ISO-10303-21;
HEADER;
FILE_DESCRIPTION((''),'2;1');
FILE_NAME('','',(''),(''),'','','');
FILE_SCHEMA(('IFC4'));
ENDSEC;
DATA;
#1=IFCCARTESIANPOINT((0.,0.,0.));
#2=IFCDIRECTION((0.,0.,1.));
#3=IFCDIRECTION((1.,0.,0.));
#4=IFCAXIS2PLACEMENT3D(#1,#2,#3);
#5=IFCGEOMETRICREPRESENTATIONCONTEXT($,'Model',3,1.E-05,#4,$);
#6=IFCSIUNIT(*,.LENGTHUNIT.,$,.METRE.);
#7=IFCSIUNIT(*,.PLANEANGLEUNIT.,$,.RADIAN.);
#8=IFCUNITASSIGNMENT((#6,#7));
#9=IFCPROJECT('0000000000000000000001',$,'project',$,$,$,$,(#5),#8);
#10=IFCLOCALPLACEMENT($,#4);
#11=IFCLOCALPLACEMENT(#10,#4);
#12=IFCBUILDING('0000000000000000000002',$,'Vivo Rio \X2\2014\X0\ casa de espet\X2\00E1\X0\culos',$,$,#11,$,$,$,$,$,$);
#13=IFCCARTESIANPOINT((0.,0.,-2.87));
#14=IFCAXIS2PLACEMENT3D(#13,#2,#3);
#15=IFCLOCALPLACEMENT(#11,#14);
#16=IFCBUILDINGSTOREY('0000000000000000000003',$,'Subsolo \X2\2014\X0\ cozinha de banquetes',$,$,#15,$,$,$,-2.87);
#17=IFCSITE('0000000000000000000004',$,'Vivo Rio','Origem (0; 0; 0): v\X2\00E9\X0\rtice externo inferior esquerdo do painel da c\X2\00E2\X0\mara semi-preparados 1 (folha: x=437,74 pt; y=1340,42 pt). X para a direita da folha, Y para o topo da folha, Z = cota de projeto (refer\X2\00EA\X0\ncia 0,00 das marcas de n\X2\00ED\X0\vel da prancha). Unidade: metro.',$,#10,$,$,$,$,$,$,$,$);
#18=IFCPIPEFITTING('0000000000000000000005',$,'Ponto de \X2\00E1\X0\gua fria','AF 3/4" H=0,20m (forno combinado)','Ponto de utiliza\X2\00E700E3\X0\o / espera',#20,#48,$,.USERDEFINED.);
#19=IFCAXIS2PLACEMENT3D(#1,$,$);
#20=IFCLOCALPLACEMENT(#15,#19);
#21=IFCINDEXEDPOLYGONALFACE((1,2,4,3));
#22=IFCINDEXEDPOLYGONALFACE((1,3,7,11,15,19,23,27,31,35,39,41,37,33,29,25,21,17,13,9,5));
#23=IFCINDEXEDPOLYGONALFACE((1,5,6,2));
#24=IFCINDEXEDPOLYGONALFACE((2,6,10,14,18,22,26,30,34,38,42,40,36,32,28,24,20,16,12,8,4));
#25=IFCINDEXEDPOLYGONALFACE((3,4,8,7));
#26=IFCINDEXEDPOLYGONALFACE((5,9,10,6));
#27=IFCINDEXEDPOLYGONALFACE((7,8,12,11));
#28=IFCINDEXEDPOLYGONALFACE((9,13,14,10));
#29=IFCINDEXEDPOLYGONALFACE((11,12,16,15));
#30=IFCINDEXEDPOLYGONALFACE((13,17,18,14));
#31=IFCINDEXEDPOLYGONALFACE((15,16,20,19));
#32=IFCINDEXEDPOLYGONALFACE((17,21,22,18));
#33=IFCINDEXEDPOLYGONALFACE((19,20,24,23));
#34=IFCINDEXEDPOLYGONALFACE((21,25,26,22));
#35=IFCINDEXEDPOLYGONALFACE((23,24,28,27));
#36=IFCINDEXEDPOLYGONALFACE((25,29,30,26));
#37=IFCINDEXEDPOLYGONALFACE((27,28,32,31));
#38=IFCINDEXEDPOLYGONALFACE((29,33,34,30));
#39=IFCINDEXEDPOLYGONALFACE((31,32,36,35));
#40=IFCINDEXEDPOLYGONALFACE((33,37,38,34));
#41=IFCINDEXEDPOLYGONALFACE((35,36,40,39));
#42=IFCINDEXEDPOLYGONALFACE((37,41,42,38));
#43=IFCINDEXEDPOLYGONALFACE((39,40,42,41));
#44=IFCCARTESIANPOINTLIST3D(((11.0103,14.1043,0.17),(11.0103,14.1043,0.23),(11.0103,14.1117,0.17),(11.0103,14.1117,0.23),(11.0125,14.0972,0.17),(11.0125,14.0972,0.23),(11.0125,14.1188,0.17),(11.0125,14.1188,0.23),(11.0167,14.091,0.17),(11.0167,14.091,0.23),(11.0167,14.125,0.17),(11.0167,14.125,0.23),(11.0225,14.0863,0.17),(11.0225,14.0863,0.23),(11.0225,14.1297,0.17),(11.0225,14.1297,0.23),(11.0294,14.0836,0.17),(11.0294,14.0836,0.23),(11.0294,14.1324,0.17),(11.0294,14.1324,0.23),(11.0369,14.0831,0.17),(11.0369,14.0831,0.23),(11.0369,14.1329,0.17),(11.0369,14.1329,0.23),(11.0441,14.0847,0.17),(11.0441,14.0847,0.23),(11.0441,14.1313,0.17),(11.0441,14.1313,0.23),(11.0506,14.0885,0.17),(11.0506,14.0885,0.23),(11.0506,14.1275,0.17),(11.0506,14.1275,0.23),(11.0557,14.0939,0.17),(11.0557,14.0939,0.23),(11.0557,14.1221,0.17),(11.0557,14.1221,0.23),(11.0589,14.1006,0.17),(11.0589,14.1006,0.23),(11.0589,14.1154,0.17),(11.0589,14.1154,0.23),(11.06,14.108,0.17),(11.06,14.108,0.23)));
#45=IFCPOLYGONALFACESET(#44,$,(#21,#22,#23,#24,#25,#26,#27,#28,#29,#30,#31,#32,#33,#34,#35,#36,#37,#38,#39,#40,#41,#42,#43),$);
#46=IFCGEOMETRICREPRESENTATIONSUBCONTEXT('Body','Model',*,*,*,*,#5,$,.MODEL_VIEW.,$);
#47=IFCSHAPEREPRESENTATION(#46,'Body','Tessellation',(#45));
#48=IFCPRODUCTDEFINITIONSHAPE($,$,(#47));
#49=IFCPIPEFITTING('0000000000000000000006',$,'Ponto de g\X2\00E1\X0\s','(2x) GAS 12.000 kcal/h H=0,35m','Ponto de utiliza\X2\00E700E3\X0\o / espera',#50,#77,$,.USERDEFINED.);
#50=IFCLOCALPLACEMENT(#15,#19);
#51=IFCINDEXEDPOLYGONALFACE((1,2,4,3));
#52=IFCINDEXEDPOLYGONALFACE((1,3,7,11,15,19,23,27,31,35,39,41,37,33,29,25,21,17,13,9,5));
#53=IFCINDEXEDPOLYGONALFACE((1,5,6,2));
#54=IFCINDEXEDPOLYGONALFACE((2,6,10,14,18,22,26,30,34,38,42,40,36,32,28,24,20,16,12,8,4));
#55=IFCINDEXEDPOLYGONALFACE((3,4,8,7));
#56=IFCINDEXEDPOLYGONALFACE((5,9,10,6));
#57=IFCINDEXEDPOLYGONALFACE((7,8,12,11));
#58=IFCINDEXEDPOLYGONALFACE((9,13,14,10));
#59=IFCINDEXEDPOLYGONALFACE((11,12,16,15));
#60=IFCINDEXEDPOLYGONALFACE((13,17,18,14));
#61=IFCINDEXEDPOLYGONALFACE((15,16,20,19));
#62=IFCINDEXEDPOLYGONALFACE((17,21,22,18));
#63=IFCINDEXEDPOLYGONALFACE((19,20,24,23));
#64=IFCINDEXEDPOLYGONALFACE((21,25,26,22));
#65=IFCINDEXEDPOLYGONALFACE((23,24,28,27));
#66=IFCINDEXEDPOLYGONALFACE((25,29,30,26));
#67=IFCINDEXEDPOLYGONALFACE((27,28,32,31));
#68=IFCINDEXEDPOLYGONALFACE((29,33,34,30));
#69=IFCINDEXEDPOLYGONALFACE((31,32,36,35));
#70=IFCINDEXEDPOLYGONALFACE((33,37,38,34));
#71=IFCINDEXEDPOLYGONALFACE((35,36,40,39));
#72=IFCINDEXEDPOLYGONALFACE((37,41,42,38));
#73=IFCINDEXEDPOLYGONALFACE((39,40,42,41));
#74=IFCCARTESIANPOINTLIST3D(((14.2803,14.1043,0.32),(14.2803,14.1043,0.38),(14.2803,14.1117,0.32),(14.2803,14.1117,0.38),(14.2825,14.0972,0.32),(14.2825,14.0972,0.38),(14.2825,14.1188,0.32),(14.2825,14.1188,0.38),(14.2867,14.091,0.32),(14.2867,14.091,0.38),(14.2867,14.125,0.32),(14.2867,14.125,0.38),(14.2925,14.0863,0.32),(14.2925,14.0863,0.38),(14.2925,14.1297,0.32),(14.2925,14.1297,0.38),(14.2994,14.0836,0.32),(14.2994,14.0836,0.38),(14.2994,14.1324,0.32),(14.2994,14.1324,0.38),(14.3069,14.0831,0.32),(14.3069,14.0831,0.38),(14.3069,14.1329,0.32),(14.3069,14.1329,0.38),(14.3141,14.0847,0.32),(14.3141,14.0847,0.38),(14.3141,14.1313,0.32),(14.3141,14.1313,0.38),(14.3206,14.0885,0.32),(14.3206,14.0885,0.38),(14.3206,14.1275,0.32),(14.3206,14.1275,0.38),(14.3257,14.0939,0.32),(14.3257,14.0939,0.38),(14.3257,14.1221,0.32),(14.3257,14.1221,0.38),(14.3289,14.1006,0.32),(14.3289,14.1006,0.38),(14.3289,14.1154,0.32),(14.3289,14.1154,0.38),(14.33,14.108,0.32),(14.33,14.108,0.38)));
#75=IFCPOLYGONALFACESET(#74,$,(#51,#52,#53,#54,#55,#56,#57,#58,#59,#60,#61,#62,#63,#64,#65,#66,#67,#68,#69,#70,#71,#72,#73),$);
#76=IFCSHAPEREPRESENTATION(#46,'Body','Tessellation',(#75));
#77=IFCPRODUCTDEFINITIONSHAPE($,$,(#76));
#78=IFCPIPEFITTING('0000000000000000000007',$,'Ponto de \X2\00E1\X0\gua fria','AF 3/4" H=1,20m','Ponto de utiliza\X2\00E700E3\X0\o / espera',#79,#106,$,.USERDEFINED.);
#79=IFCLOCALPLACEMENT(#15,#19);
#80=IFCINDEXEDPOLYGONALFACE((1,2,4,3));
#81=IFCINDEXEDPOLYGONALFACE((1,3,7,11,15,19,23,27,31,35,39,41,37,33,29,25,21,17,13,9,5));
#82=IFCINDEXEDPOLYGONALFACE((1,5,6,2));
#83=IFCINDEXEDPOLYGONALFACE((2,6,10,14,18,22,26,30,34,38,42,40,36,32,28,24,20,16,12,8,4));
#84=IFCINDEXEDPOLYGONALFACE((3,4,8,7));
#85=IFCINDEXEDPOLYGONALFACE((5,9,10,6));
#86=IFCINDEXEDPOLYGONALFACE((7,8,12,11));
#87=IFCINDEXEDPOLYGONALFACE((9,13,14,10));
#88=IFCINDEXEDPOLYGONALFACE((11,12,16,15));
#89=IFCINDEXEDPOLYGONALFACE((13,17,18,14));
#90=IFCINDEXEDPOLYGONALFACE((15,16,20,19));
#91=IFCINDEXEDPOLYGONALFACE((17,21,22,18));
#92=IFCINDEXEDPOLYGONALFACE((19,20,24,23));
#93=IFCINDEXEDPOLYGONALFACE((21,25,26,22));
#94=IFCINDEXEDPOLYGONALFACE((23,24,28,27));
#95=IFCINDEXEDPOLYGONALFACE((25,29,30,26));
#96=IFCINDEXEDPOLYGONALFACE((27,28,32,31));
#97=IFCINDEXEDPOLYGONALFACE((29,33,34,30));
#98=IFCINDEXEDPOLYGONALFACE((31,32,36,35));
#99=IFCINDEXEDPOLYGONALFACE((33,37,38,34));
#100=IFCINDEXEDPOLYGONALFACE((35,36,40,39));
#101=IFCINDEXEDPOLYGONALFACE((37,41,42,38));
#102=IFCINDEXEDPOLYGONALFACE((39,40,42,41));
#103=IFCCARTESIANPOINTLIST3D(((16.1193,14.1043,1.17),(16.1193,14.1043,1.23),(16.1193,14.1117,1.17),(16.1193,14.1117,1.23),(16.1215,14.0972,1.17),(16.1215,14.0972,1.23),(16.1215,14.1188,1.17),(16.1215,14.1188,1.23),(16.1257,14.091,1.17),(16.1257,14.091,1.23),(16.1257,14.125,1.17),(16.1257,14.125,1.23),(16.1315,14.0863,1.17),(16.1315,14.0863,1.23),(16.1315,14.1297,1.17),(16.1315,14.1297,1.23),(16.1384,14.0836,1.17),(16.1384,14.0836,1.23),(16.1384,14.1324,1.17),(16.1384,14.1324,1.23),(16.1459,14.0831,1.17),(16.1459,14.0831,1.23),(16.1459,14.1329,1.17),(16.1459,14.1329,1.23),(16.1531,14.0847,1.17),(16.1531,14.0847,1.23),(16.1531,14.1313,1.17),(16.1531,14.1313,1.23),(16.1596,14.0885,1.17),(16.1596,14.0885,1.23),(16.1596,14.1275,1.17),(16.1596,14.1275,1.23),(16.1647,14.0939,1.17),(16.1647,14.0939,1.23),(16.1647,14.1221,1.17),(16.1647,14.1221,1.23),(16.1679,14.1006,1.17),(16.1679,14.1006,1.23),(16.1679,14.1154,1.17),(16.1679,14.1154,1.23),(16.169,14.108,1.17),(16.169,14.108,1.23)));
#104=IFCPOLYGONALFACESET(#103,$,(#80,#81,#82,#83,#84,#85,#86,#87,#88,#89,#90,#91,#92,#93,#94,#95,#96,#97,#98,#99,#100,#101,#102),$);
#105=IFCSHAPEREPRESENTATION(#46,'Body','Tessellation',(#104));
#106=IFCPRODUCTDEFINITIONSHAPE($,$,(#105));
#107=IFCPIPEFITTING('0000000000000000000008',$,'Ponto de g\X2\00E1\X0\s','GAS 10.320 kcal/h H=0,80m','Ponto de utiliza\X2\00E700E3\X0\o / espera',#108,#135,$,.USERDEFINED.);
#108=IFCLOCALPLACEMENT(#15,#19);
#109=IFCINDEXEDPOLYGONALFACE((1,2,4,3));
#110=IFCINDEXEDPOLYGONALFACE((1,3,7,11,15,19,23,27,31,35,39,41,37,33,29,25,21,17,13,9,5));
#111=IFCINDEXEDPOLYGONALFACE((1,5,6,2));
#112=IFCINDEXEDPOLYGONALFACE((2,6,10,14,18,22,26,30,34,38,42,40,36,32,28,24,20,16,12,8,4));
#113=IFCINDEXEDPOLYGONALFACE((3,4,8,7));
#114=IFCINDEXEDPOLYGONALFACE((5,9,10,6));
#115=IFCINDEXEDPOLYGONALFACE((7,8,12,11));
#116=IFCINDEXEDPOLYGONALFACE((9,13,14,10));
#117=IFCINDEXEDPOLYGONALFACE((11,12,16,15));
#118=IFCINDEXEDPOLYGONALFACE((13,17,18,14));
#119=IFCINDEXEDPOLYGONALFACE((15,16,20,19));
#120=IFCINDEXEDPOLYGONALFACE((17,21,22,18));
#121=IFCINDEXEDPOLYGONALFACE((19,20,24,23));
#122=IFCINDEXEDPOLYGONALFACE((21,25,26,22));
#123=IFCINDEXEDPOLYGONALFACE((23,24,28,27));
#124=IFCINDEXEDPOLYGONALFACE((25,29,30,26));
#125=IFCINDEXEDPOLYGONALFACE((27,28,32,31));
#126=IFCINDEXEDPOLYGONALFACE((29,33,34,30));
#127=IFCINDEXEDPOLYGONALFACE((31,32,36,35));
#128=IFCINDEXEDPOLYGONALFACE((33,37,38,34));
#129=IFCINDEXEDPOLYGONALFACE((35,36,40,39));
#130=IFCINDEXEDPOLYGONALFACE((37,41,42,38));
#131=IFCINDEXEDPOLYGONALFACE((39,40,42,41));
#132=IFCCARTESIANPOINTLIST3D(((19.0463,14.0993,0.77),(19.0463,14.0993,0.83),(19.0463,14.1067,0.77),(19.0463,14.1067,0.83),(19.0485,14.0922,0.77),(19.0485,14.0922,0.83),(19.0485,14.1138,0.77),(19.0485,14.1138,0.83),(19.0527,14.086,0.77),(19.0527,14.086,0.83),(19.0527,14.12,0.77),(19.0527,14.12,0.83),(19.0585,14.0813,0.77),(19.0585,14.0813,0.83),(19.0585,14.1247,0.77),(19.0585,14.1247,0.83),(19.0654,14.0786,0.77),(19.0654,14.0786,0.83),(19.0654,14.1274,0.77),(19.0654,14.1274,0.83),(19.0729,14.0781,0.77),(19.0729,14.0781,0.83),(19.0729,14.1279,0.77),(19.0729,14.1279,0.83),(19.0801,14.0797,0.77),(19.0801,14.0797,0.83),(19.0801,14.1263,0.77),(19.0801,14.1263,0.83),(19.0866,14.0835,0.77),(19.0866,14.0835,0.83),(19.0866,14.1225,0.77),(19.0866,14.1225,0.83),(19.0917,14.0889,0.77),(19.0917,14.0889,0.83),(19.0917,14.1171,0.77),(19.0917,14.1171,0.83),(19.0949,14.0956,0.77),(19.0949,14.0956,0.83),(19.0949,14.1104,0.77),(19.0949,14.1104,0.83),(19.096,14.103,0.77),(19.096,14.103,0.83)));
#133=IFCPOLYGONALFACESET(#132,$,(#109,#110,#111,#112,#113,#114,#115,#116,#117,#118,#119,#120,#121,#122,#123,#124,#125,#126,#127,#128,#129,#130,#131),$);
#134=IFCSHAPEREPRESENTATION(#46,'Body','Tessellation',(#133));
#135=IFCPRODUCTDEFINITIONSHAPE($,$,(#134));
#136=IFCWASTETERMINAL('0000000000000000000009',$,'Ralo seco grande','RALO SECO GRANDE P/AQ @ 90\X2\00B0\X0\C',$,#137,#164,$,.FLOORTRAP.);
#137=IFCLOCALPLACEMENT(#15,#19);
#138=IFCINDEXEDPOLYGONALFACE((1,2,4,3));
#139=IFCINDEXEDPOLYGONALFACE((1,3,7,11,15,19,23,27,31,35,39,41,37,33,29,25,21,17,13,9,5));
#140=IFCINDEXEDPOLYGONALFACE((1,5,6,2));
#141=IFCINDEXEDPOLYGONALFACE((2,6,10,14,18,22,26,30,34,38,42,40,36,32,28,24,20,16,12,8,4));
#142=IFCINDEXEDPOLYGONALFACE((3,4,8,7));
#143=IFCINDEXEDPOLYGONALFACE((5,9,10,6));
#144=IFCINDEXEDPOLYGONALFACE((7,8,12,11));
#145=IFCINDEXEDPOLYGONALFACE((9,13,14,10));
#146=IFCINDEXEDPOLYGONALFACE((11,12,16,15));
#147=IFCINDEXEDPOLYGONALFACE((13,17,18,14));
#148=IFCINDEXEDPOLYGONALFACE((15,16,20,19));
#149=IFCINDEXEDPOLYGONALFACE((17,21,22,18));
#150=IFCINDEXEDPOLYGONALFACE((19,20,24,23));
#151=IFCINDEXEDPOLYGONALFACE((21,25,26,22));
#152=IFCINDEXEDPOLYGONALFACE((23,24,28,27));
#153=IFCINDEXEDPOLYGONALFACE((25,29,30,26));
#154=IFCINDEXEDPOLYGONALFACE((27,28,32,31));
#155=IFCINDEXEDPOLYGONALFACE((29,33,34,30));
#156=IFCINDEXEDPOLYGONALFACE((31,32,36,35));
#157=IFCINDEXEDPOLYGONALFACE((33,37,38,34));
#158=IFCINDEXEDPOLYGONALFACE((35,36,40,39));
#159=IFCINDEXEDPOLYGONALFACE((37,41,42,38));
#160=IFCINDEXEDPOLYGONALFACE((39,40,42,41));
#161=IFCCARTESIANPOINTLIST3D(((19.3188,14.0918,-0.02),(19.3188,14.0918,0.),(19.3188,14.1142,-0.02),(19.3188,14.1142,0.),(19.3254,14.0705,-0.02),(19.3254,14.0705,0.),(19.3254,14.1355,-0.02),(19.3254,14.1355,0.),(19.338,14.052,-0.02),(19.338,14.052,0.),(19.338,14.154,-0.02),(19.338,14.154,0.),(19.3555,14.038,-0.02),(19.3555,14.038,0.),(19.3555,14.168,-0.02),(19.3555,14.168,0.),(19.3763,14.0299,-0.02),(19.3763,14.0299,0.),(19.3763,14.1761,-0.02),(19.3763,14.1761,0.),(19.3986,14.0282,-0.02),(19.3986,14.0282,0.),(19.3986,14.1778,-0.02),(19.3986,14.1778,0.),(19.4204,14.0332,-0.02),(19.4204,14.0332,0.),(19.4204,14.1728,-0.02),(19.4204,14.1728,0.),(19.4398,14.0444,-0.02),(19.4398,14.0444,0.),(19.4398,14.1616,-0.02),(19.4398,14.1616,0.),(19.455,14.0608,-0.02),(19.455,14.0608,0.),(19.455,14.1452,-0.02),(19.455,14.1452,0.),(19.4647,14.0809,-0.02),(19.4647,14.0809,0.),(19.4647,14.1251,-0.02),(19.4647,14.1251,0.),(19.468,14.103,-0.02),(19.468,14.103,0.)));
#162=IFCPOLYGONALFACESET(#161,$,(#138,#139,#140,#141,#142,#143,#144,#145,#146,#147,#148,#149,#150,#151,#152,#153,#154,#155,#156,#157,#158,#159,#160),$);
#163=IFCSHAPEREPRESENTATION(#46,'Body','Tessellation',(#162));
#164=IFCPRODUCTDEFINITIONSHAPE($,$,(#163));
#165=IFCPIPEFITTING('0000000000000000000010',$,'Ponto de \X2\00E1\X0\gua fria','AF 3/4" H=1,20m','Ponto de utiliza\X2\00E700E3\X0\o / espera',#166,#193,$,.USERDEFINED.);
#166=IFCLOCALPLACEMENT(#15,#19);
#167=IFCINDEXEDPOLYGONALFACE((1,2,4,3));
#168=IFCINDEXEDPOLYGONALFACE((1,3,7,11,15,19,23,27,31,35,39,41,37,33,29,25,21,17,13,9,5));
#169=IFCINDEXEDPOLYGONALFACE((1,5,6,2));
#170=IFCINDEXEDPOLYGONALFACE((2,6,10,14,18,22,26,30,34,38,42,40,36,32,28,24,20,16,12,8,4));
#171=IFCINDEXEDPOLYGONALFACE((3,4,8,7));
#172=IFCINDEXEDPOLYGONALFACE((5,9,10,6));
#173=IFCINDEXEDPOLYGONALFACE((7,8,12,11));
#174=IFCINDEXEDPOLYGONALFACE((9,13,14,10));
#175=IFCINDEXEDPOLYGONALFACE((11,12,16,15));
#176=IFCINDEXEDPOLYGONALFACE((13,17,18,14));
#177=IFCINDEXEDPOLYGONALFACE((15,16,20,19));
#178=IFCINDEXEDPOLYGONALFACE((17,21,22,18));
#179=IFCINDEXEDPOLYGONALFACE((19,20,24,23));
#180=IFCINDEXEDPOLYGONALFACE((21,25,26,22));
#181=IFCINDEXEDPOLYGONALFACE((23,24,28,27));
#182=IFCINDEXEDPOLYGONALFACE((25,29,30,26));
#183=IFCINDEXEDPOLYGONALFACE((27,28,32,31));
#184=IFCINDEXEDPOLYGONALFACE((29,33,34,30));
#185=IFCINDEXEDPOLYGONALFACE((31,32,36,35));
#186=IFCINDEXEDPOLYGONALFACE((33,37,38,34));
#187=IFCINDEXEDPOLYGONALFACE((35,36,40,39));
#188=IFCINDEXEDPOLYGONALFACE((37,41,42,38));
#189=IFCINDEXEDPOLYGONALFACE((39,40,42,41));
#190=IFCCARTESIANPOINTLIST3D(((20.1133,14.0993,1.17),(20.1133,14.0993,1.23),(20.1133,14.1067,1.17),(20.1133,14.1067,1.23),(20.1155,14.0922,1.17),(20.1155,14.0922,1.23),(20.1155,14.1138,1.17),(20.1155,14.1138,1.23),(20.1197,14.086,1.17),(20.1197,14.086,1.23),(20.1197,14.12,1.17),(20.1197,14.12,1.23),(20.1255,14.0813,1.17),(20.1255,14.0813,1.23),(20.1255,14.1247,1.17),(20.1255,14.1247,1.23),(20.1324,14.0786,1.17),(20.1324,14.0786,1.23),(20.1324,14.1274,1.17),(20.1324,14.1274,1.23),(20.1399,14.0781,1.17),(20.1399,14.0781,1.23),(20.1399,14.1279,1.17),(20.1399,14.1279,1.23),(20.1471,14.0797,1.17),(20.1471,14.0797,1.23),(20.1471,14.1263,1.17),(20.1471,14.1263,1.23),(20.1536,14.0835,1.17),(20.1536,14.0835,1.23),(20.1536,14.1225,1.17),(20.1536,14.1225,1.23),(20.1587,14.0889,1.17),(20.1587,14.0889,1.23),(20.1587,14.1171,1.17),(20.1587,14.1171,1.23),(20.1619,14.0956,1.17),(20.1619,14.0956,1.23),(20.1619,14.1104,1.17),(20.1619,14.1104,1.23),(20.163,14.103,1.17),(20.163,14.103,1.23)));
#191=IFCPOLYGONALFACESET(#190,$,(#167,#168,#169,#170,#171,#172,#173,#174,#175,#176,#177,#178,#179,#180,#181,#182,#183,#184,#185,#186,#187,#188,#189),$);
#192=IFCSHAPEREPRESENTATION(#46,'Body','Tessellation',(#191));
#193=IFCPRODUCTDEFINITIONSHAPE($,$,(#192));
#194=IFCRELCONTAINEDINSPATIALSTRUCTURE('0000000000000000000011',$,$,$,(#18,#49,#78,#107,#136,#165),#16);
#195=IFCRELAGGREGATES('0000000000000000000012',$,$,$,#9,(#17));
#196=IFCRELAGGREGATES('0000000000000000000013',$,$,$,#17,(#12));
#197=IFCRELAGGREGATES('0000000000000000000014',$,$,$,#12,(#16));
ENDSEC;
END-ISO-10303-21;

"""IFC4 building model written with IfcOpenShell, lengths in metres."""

from ifc_helpers import new_model, si_unit, frame, origin_with_axes, origin_2d, place, context, subcontext, project, spatial, circle, extrude, element, save


model = new_model("IFC4")

# Units and contexts
model_context = context("Model", 3, precision=1e-05, world=origin_with_axes())
body_context = subcontext(model_context, "Body", "Model", "MODEL_VIEW")
ifc_project = project(units=[si_unit("LENGTHUNIT", "METRE"), si_unit("PLANEANGLEUNIT", "RADIAN")], contexts=[model_context])

# Site, building, storey
site_placement = place(None, origin_with_axes())
site = spatial("IfcSite", under=ifc_project, at=site_placement, Name="Vivo Rio", Description="Origem (0; 0; 0): vértice externo inferior esquerdo do painel da câmara semi-preparados 1 (folha: x=437,74 pt; y=1340,42 pt). X para a direita da folha, Y para o topo da folha, Z = cota de projeto (referência 0,00 das marcas de nível da prancha). Unidade: metro.")
building_placement = place(site_placement, origin_with_axes())
building = spatial("IfcBuilding", under=site, at=building_placement, Name="Vivo Rio — casa de espetáculos")
storey_placement = place(building_placement, frame((0.0, 0.0, -2.87), z_axis=(0.0, 0.0, 1.0), x_axis=(1.0, 0.0, 0.0)))
storey = spatial("IfcBuildingStorey", under=building, at=storey_placement, Name="Subsolo — cozinha de banquetes", Elevation=-2.87)

# Pipe fittings
pipe_fitting_1_placement = place(storey_placement, origin_with_axes())
element("IfcPipeFitting", 1, at=pipe_fitting_1_placement, inside=storey, Name="Ponto de água fria", Description="AF 3/4\" H=0,20m (forno combinado)", ObjectType="Ponto de utilização / espera", PredefinedType="USERDEFINED", context=body_context, shape_type="SweptSolid", body=[
    extrude(circle(Radius=0.025, at=origin_2d()), frame((11.035, 14.108, 0.17), z_axis=(0.0, 0.0, 1.0), x_axis=(1.0, 0.0, 0.0)), (0.0, 0.0, 1.0), 0.06),
])
pipe_fitting_2_placement = place(storey_placement, origin_with_axes())
element("IfcPipeFitting", 2, at=pipe_fitting_2_placement, inside=storey, Name="Ponto de gás", Description="(2x) GAS 12.000 kcal/h H=0,35m", ObjectType="Ponto de utilização / espera", PredefinedType="USERDEFINED", context=body_context, shape_type="SweptSolid", body=[
    extrude(circle(Radius=0.025, at=origin_2d()), frame((14.305, 14.108, 0.32), z_axis=(0.0, 0.0, 1.0), x_axis=(1.0, 0.0, 0.0)), (0.0, 0.0, 1.0), 0.06),
])
pipe_fitting_3_placement = place(storey_placement, origin_with_axes())
element("IfcPipeFitting", 3, at=pipe_fitting_3_placement, inside=storey, Name="Ponto de água fria", Description="AF 3/4\" H=1,20m", ObjectType="Ponto de utilização / espera", PredefinedType="USERDEFINED", context=body_context, shape_type="SweptSolid", body=[
    extrude(circle(Radius=0.025, at=origin_2d()), frame((16.144, 14.108, 1.17), z_axis=(0.0, 0.0, 1.0), x_axis=(1.0, 0.0, 0.0)), (0.0, 0.0, 1.0), 0.06),
])
pipe_fitting_4_placement = place(storey_placement, origin_with_axes())
element("IfcPipeFitting", 4, at=pipe_fitting_4_placement, inside=storey, Name="Ponto de gás", Description="GAS 10.320 kcal/h H=0,80m", ObjectType="Ponto de utilização / espera", PredefinedType="USERDEFINED", context=body_context, shape_type="SweptSolid", body=[
    extrude(circle(Radius=0.025, at=origin_2d()), frame((19.071, 14.103, 0.77), z_axis=(0.0, 0.0, 1.0), x_axis=(1.0, 0.0, 0.0)), (0.0, 0.0, 1.0), 0.06),
])

# Waste terminal
waste_terminal_1_placement = place(storey_placement, origin_with_axes())
element("IfcWasteTerminal", 5, at=waste_terminal_1_placement, inside=storey, Name="Ralo seco grande", Description="RALO SECO GRANDE P/AQ @ 90°C", PredefinedType="FLOORTRAP", context=body_context, shape_type="SweptSolid", body=[
    extrude(circle(Radius=0.075, at=origin_2d()), frame((19.393, 14.103, -0.02), z_axis=(0.0, 0.0, 1.0), x_axis=(1.0, 0.0, 0.0)), (0.0, 0.0, 1.0), 0.02),
])

# Pipe fitting
pipe_fitting_5_placement = place(storey_placement, origin_with_axes())
element("IfcPipeFitting", 6, at=pipe_fitting_5_placement, inside=storey, Name="Ponto de água fria", Description="AF 3/4\" H=1,20m", ObjectType="Ponto de utilização / espera", PredefinedType="USERDEFINED", context=body_context, shape_type="SweptSolid", body=[
    extrude(circle(Radius=0.025, at=origin_2d()), frame((20.138, 14.103, 1.17), z_axis=(0.0, 0.0, 1.0), x_axis=(1.0, 0.0, 0.0)), (0.0, 0.0, 1.0), 0.06),
])

save(model, "model.ifc")
